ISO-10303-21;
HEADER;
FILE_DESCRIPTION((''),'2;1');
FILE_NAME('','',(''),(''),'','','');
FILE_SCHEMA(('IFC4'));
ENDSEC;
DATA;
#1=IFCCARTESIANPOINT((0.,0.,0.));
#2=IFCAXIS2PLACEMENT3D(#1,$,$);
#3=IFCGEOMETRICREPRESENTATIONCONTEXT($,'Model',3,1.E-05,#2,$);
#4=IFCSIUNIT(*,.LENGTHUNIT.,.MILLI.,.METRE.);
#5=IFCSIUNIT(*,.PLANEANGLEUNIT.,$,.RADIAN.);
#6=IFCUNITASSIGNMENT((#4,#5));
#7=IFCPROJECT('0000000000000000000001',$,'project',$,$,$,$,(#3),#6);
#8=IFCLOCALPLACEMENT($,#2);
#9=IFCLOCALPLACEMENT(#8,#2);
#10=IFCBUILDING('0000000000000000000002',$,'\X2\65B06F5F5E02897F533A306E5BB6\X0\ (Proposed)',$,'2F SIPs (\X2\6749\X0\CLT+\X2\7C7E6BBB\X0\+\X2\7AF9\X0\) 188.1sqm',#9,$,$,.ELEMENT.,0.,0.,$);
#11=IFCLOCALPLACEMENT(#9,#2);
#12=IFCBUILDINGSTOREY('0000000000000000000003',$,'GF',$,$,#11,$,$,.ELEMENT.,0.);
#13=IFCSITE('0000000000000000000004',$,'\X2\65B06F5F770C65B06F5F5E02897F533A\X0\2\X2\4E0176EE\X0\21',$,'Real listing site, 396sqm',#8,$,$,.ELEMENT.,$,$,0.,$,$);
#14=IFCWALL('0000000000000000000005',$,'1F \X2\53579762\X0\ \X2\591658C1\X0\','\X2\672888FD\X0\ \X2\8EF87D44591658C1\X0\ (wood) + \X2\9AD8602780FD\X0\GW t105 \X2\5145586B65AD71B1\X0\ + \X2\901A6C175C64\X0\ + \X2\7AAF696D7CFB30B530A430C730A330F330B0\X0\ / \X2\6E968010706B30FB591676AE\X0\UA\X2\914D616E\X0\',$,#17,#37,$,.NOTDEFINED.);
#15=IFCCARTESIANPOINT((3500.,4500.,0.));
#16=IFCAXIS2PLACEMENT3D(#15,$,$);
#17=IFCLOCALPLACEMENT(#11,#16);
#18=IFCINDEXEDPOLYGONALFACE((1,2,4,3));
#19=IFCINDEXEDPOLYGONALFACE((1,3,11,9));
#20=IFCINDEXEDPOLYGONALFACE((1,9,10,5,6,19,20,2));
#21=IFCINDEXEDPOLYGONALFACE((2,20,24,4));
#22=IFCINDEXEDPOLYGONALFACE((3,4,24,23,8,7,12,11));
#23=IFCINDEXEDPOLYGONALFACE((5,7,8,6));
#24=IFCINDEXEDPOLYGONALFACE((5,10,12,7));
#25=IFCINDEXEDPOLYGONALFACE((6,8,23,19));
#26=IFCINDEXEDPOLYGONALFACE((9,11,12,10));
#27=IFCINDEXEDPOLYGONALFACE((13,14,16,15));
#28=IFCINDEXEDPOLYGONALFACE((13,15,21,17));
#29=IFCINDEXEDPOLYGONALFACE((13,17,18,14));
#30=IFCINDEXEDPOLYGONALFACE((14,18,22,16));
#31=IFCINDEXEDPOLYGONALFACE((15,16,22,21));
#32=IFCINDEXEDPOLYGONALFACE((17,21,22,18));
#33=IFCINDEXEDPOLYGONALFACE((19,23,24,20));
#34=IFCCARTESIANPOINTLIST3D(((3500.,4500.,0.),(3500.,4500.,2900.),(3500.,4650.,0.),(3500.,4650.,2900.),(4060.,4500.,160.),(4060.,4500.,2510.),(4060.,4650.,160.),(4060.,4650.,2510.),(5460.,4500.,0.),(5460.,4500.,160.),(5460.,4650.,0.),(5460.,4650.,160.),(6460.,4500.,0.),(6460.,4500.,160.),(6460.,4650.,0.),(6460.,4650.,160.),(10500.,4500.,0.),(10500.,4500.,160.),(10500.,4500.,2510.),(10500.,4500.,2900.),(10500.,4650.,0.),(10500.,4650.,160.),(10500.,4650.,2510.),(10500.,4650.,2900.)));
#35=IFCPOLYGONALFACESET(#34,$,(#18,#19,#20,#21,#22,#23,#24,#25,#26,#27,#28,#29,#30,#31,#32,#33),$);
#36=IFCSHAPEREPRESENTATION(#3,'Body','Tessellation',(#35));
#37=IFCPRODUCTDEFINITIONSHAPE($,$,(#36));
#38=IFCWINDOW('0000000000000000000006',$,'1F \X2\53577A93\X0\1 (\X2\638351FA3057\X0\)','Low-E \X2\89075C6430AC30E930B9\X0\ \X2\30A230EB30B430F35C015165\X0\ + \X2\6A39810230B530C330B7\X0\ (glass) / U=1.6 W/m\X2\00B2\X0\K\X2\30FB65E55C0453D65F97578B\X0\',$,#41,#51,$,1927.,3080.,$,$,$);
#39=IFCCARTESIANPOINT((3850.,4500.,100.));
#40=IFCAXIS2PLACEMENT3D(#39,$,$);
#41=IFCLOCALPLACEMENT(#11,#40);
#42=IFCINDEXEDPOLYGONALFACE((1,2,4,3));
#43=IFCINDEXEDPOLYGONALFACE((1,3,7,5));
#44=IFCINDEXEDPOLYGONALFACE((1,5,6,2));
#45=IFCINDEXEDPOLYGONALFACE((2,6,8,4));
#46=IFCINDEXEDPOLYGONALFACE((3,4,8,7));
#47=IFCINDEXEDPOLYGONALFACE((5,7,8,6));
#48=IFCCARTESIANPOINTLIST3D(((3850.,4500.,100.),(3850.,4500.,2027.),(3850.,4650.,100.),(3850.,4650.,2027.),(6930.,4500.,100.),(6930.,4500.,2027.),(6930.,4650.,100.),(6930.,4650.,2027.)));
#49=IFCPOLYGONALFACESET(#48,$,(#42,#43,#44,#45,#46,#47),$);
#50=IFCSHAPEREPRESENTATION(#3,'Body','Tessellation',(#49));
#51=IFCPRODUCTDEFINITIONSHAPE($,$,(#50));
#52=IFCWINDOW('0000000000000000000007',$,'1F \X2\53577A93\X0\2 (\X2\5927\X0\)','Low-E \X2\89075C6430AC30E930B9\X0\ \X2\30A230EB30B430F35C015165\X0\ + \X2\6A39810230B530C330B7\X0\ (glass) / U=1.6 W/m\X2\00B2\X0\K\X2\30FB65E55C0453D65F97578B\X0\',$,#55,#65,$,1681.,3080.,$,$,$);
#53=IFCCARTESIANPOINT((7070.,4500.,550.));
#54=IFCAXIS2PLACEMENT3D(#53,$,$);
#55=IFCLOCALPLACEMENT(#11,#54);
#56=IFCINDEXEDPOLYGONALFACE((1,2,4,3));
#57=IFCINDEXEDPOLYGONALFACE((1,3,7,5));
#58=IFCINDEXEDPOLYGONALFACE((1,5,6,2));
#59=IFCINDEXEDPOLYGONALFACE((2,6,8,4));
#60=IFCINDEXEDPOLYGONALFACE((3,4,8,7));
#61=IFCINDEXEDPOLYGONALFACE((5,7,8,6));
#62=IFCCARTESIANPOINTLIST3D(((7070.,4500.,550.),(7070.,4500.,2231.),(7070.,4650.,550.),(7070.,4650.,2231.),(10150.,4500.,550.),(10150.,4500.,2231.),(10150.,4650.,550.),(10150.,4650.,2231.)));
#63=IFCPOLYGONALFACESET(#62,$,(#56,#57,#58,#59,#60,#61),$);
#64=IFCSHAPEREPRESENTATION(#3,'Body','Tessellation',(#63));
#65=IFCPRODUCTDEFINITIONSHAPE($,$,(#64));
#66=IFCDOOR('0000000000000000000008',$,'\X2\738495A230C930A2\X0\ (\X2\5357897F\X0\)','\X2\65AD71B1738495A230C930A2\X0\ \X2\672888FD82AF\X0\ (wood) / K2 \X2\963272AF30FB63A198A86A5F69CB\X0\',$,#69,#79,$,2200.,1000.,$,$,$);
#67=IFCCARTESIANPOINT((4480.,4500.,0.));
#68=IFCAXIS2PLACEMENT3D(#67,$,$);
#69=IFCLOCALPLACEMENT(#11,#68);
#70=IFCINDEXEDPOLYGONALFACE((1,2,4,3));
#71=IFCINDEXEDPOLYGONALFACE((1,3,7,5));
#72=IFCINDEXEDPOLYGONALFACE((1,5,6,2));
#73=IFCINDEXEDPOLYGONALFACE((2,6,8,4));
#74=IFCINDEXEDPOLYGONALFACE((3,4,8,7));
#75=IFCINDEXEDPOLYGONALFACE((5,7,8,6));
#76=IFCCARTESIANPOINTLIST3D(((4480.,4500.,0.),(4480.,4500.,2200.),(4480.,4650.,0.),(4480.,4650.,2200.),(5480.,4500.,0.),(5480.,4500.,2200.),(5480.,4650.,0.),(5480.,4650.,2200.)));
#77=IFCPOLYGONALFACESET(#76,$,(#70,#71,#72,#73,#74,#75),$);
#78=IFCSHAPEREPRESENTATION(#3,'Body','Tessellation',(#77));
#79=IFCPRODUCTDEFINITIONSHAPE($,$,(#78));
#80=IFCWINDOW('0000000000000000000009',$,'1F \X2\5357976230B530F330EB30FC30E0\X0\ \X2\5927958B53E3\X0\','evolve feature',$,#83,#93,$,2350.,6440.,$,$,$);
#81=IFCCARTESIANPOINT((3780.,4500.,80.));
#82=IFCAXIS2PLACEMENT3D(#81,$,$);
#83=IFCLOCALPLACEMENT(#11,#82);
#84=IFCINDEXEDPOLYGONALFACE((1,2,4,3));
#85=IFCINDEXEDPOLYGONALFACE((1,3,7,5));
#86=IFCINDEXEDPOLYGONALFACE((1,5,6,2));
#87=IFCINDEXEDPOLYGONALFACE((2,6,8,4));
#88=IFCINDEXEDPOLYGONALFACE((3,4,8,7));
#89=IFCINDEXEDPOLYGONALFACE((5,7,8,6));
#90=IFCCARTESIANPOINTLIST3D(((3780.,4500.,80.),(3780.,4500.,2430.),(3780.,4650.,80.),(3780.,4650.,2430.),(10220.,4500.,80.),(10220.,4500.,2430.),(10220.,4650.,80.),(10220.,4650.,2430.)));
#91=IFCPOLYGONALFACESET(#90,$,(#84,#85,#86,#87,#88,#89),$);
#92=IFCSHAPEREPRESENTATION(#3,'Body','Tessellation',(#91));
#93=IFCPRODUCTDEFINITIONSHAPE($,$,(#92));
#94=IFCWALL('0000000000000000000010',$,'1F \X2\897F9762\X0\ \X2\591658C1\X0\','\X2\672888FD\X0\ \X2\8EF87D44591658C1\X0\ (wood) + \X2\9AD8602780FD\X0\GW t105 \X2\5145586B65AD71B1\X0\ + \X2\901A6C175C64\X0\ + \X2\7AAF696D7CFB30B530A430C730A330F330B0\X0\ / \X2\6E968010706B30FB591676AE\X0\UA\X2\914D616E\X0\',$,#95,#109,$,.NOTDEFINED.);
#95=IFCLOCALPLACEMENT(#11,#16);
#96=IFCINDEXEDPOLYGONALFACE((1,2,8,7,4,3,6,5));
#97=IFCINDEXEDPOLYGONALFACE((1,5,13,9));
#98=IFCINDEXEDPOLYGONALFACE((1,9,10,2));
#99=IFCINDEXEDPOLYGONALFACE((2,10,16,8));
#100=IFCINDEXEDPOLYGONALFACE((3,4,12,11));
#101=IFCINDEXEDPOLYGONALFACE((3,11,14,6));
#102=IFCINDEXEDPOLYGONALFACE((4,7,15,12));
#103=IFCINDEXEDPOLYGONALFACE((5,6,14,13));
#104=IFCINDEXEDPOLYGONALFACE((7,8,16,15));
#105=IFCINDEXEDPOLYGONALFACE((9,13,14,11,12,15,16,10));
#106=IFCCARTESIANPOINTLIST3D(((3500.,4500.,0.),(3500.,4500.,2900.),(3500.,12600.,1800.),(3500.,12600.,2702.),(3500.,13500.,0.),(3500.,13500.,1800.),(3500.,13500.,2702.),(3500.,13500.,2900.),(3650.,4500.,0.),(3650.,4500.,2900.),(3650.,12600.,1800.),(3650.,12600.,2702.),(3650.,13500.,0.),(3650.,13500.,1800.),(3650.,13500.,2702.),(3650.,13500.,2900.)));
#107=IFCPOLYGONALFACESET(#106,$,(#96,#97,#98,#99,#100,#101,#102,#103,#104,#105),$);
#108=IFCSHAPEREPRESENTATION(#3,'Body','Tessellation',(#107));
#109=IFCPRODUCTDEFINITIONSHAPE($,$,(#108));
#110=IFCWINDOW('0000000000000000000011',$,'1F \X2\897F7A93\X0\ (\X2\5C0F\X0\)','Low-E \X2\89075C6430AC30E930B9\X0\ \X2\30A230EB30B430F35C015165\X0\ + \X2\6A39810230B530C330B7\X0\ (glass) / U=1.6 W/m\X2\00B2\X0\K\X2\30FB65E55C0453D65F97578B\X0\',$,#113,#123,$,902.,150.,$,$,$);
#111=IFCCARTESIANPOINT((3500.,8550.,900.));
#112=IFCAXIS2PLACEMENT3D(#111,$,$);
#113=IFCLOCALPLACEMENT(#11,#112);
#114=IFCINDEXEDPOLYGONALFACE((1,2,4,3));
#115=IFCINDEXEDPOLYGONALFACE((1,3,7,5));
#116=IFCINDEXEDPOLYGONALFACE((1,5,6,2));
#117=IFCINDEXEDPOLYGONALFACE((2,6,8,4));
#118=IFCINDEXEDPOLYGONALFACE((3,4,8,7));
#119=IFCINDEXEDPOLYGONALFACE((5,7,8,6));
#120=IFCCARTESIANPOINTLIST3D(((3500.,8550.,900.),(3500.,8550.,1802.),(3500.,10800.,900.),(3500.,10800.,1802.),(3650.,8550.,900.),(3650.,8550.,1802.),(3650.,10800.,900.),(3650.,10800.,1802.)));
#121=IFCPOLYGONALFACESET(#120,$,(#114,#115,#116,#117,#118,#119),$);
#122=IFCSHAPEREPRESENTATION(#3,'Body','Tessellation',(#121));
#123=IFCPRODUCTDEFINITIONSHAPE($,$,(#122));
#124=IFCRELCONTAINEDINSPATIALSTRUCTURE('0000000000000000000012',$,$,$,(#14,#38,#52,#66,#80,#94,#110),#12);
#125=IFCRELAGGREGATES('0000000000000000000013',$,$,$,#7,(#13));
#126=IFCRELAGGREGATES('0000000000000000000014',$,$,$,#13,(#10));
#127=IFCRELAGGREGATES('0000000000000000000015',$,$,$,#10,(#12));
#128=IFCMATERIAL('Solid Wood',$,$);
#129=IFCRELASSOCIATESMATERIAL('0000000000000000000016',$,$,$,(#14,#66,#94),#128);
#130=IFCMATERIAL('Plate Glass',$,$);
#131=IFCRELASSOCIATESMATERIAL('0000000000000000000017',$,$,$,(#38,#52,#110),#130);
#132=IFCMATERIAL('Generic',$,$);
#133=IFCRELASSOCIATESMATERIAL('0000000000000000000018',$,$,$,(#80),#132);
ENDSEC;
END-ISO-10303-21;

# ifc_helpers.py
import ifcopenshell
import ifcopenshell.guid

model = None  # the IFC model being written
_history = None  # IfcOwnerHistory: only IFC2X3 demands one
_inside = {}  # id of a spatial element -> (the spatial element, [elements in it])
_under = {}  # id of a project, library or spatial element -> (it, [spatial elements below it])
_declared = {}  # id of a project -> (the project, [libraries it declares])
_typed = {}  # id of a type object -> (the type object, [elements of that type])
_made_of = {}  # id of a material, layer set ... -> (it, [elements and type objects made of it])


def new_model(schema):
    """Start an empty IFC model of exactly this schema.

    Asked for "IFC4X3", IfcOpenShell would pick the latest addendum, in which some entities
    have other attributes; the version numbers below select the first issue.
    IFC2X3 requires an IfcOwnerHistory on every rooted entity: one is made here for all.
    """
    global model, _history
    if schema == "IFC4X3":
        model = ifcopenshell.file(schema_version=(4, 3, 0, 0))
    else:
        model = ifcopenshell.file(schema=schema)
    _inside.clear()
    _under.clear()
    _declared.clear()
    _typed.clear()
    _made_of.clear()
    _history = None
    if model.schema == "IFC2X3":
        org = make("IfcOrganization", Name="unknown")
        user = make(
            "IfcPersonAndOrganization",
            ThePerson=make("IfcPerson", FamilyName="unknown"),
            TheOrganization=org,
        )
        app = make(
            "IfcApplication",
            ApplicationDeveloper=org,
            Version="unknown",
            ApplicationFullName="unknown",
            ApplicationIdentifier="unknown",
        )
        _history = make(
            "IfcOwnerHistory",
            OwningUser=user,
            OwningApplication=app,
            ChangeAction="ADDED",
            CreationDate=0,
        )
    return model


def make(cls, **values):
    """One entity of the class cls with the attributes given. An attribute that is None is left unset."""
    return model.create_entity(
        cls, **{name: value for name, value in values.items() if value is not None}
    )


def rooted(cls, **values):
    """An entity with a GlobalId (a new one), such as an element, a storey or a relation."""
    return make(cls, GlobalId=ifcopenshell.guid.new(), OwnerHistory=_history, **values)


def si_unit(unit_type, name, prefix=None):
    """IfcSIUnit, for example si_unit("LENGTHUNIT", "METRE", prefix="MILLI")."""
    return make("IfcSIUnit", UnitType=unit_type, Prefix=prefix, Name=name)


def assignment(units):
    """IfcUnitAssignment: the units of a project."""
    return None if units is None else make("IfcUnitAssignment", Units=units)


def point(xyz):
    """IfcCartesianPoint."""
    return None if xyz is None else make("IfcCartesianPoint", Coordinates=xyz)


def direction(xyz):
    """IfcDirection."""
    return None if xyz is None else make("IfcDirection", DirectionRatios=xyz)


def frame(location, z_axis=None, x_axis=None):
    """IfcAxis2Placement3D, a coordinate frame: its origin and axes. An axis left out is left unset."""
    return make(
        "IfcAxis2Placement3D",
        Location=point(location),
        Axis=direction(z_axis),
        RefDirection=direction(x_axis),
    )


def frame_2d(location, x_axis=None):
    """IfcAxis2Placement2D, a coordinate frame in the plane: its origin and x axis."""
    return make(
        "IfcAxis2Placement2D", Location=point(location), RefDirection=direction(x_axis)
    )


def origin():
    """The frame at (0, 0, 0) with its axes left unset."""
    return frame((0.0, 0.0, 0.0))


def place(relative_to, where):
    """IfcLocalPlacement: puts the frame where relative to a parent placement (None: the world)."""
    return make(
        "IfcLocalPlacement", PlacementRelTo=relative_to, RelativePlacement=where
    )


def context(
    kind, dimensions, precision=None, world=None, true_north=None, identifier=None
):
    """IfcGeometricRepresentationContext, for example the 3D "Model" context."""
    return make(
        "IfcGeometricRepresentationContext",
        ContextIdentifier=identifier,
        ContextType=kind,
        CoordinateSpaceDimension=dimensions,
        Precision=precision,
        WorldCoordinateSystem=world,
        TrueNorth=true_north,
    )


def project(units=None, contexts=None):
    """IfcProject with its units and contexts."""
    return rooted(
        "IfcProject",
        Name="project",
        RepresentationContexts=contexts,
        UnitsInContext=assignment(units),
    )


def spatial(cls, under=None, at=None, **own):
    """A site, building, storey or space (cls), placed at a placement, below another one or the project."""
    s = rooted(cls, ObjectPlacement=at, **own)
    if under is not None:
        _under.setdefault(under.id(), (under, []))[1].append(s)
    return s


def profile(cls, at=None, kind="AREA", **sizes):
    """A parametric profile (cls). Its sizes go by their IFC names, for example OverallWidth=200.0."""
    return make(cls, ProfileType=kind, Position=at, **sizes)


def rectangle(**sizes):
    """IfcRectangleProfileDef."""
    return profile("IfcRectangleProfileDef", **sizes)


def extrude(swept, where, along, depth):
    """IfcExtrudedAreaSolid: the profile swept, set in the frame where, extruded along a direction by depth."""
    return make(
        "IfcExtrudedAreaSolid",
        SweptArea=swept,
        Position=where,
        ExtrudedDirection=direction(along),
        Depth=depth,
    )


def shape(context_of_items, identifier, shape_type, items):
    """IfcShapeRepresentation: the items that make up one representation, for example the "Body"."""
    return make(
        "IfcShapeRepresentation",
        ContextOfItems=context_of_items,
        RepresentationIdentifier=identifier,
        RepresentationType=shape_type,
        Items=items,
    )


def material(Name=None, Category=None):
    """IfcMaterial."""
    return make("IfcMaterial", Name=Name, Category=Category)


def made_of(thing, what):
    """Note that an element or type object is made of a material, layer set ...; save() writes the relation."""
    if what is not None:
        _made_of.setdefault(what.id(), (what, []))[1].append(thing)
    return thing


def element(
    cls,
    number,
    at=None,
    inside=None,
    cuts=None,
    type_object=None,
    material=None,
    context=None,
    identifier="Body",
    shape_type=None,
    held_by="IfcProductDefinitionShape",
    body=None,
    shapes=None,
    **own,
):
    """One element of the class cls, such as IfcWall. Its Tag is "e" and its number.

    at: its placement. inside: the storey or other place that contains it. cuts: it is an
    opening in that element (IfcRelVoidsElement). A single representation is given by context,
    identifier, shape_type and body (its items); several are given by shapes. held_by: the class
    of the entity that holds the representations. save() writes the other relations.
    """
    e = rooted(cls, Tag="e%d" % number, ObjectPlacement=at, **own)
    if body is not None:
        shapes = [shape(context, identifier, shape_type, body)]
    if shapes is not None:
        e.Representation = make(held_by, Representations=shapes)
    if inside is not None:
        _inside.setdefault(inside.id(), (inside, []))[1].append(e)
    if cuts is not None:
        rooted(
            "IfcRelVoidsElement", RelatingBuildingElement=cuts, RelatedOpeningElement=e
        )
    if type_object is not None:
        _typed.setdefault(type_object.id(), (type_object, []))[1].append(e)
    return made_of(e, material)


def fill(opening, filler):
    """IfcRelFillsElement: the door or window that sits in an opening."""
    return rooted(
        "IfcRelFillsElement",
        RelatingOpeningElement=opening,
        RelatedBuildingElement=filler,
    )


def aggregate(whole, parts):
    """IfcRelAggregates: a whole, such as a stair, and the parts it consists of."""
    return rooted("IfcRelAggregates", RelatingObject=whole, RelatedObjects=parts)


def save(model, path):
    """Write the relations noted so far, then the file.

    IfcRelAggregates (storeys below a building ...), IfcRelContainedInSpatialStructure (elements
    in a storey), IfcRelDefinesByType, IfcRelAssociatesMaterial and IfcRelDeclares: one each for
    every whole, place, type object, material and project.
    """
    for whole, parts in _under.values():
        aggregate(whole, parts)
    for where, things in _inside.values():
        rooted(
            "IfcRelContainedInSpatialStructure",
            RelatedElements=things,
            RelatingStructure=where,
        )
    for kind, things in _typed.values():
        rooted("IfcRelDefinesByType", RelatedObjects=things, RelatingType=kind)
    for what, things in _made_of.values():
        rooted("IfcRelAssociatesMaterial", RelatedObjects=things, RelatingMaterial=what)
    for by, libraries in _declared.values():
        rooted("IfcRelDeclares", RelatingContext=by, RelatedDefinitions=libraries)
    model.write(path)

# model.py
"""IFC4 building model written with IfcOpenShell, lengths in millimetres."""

from ifc_helpers import new_model, si_unit, frame, frame_2d, origin, place, context, project, spatial, rectangle, extrude, material, element, fill, save


model = new_model("IFC4")

# Units and contexts
model_context = context("Model", 3, precision=1e-05, world=origin())
ifc_project = project(units=[si_unit("LENGTHUNIT", "METRE", prefix="MILLI"), si_unit("PLANEANGLEUNIT", "RADIAN")], contexts=[model_context])

# Site, building, storey
site_placement = place(None, origin())
site = spatial("IfcSite", under=ifc_project, at=site_placement, Name="新潟県新潟市西区2丁目21", ObjectType="Real listing site, 396sqm", CompositionType="ELEMENT", RefElevation=0.0)
building_placement = place(site_placement, origin())
building = spatial("IfcBuilding", under=site, at=building_placement, Name="新潟市西区の家 (Proposed)", ObjectType="2F SIPs (杉CLT+籾殻+竹) 188.1sqm", CompositionType="ELEMENT", ElevationOfRefHeight=0.0, ElevationOfTerrain=0.0)
storey_placement = place(building_placement, origin())
storey = spatial("IfcBuildingStorey", under=building, at=storey_placement, Name="GF", CompositionType="ELEMENT", Elevation=0.0)

# Shared definitions
ifc_material_1 = material(Name="Solid Wood")
ifc_material_2 = material(Name="Generic")

# Wall, openings, windows, door
wall_1_placement = place(storey_placement, frame((3500.0, 4500.0, 0.0)))
wall_1 = element("IfcWall", 1, at=wall_1_placement, inside=storey, material=ifc_material_1, Name="1F 南面 外壁", Description="木製 軸組外壁 (wood) + 高性能GW t105 充填断熱 + 通気層 + 窯業系サイディング / 準耐火・外皮UA配慮", PredefinedType="NOTDEFINED", context=model_context, shape_type="SweptSolid", body=[
    extrude(rectangle(XDim=7000.0, YDim=150.0, at=frame_2d((3500.0, 75.0))), frame((3500.0, 4500.0, 0.0)), (0.0, 0.0, 1.0), 2900.0),
])
opening_1_placement = place(storey_placement, frame((3850.0, 4500.0, 100.0)))
opening_1 = element("IfcOpeningElement", 2, at=opening_1_placement, cuts=wall_1, PredefinedType="NOTDEFINED", context=model_context, shape_type="SweptSolid", body=[
    extrude(rectangle(XDim=3080.0, YDim=150.0, at=frame_2d((1540.0, 75.0))), frame((3850.0, 4500.0, 100.0)), (0.0, 0.0, 1.0), 1927.0),
])
opening_2_placement = place(storey_placement, frame((7070.0, 4500.0, 550.0)))
opening_2 = element("IfcOpeningElement", 3, at=opening_2_placement, cuts=wall_1, PredefinedType="NOTDEFINED", context=model_context, shape_type="SweptSolid", body=[
    extrude(rectangle(XDim=3080.0, YDim=150.0, at=frame_2d((1540.0, 75.0))), frame((7070.0, 4500.0, 550.0)), (0.0, 0.0, 1.0), 1681.0),
])
opening_3_placement = place(storey_placement, frame((4480.0, 4500.0, 0.0)))
opening_3 = element("IfcOpeningElement", 4, at=opening_3_placement, cuts=wall_1, PredefinedType="NOTDEFINED", context=model_context, shape_type="SweptSolid", body=[
    extrude(rectangle(XDim=1000.0, YDim=150.0, at=frame_2d((500.0, 75.0))), frame((4480.0, 4500.0, 0.0)), (0.0, 0.0, 1.0), 2200.0),
])
opening_4_placement = place(storey_placement, frame((3780.0, 4500.0, 80.0)))
opening_4 = element("IfcOpeningElement", 5, at=opening_4_placement, cuts=wall_1, PredefinedType="NOTDEFINED", context=model_context, shape_type="SweptSolid", body=[
    extrude(rectangle(XDim=6440.0, YDim=150.0, at=frame_2d((3220.0, 75.0))), frame((3780.0, 4500.0, 80.0)), (0.0, 0.0, 1.0), 2350.0),
])
ifc_material_3 = material(Name="Plate Glass")
window_1_placement = place(storey_placement, frame((3850.0, 4500.0, 100.0)))
window_1 = element("IfcWindow", 6, at=window_1_placement, inside=storey, material=ifc_material_3, Name="1F 南窓1 (掃出し)", Description="Low-E 複層ガラス アルゴン封入 + 樹脂サッシ (glass) / U=1.6 W/m²K・日射取得型", OverallHeight=1927.0, OverallWidth=3080.0, context=model_context, shape_type="SweptSolid", body=[
    extrude(rectangle(XDim=3080.0, YDim=150.0, at=frame_2d((1540.0, 75.0))), frame((3850.0, 4500.0, 100.0)), (0.0, 0.0, 1.0), 1927.0),
])
fill(opening_1, window_1)
window_2_placement = place(storey_placement, frame((7070.0, 4500.0, 550.0)))
window_2 = element("IfcWindow", 7, at=window_2_placement, inside=storey, material=ifc_material_3, Name="1F 南窓2 (大)", Description="Low-E 複層ガラス アルゴン封入 + 樹脂サッシ (glass) / U=1.6 W/m²K・日射取得型", OverallHeight=1681.0, OverallWidth=3080.0, context=model_context, shape_type="SweptSolid", body=[
    extrude(rectangle(XDim=3080.0, YDim=150.0, at=frame_2d((1540.0, 75.0))), frame((7070.0, 4500.0, 550.0)), (0.0, 0.0, 1.0), 1681.0),
])
fill(opening_2, window_2)
door_placement = place(storey_placement, frame((4480.0, 4500.0, 0.0)))
door = element("IfcDoor", 8, at=door_placement, inside=storey, material=ifc_material_1, Name="玄関ドア (南西)", Description="断熱玄関ドア 木製芯 (wood) / K2 防犯・採風機構", OverallHeight=2200.0, OverallWidth=1000.0, context=model_context, shape_type="SweptSolid", body=[
    extrude(rectangle(XDim=1000.0, YDim=150.0, at=frame_2d((500.0, 75.0))), frame((4480.0, 4500.0, 0.0)), (0.0, 0.0, 1.0), 2200.0),
])
fill(opening_3, door)
window_3_placement = place(storey_placement, frame((3780.0, 4500.0, 80.0)))
window_3 = element("IfcWindow", 9, at=window_3_placement, inside=storey, material=ifc_material_2, Name="1F 南面サンルーム 大開口", Description="evolve feature", OverallHeight=2350.0, OverallWidth=6440.0, context=model_context, shape_type="SweptSolid", body=[
    extrude(rectangle(XDim=6440.0, YDim=150.0, at=frame_2d((3220.0, 75.0))), frame((3780.0, 4500.0, 80.0)), (0.0, 0.0, 1.0), 2350.0),
])
fill(opening_4, window_3)

# Wall, opening, window
wall_2_placement = place(storey_placement, frame((3500.0, 4500.0, 0.0)))
wall_2 = element("IfcWall", 10, at=wall_2_placement, inside=storey, material=ifc_material_1, Name="1F 西面 外壁", Description="木製 軸組外壁 (wood) + 高性能GW t105 充填断熱 + 通気層 + 窯業系サイディング / 準耐火・外皮UA配慮", PredefinedType="NOTDEFINED", context=model_context, shape_type="SweptSolid", body=[
    extrude(rectangle(XDim=150.0, YDim=9000.0, at=frame_2d((75.0, 4500.0))), frame((3500.0, 4500.0, 0.0)), (0.0, 0.0, 1.0), 2900.0),
])
opening_5_placement = place(storey_placement, frame((3500.0, 8550.0, 900.0)))
opening_5 = element("IfcOpeningElement", 11, at=opening_5_placement, cuts=wall_2, PredefinedType="NOTDEFINED", context=model_context, shape_type="SweptSolid", body=[
    extrude(rectangle(XDim=150.0, YDim=2250.0, at=frame_2d((75.0, 1125.0))), frame((3500.0, 8550.0, 900.0)), (0.0, 0.0, 1.0), 902.0),
])
window_4_placement = place(storey_placement, frame((3500.0, 8550.0, 900.0)))
window_4 = element("IfcWindow", 12, at=window_4_placement, inside=storey, material=ifc_material_3, Name="1F 西窓 (小)", Description="Low-E 複層ガラス アルゴン封入 + 樹脂サッシ (glass) / U=1.6 W/m²K・日射取得型", OverallHeight=902.0, OverallWidth=150.0, context=model_context, shape_type="SweptSolid", body=[
    extrude(rectangle(XDim=150.0, YDim=2250.0, at=frame_2d((75.0, 1125.0))), frame((3500.0, 8550.0, 900.0)), (0.0, 0.0, 1.0), 902.0),
])
fill(opening_5, window_4)

save(model, "model.ifc")
